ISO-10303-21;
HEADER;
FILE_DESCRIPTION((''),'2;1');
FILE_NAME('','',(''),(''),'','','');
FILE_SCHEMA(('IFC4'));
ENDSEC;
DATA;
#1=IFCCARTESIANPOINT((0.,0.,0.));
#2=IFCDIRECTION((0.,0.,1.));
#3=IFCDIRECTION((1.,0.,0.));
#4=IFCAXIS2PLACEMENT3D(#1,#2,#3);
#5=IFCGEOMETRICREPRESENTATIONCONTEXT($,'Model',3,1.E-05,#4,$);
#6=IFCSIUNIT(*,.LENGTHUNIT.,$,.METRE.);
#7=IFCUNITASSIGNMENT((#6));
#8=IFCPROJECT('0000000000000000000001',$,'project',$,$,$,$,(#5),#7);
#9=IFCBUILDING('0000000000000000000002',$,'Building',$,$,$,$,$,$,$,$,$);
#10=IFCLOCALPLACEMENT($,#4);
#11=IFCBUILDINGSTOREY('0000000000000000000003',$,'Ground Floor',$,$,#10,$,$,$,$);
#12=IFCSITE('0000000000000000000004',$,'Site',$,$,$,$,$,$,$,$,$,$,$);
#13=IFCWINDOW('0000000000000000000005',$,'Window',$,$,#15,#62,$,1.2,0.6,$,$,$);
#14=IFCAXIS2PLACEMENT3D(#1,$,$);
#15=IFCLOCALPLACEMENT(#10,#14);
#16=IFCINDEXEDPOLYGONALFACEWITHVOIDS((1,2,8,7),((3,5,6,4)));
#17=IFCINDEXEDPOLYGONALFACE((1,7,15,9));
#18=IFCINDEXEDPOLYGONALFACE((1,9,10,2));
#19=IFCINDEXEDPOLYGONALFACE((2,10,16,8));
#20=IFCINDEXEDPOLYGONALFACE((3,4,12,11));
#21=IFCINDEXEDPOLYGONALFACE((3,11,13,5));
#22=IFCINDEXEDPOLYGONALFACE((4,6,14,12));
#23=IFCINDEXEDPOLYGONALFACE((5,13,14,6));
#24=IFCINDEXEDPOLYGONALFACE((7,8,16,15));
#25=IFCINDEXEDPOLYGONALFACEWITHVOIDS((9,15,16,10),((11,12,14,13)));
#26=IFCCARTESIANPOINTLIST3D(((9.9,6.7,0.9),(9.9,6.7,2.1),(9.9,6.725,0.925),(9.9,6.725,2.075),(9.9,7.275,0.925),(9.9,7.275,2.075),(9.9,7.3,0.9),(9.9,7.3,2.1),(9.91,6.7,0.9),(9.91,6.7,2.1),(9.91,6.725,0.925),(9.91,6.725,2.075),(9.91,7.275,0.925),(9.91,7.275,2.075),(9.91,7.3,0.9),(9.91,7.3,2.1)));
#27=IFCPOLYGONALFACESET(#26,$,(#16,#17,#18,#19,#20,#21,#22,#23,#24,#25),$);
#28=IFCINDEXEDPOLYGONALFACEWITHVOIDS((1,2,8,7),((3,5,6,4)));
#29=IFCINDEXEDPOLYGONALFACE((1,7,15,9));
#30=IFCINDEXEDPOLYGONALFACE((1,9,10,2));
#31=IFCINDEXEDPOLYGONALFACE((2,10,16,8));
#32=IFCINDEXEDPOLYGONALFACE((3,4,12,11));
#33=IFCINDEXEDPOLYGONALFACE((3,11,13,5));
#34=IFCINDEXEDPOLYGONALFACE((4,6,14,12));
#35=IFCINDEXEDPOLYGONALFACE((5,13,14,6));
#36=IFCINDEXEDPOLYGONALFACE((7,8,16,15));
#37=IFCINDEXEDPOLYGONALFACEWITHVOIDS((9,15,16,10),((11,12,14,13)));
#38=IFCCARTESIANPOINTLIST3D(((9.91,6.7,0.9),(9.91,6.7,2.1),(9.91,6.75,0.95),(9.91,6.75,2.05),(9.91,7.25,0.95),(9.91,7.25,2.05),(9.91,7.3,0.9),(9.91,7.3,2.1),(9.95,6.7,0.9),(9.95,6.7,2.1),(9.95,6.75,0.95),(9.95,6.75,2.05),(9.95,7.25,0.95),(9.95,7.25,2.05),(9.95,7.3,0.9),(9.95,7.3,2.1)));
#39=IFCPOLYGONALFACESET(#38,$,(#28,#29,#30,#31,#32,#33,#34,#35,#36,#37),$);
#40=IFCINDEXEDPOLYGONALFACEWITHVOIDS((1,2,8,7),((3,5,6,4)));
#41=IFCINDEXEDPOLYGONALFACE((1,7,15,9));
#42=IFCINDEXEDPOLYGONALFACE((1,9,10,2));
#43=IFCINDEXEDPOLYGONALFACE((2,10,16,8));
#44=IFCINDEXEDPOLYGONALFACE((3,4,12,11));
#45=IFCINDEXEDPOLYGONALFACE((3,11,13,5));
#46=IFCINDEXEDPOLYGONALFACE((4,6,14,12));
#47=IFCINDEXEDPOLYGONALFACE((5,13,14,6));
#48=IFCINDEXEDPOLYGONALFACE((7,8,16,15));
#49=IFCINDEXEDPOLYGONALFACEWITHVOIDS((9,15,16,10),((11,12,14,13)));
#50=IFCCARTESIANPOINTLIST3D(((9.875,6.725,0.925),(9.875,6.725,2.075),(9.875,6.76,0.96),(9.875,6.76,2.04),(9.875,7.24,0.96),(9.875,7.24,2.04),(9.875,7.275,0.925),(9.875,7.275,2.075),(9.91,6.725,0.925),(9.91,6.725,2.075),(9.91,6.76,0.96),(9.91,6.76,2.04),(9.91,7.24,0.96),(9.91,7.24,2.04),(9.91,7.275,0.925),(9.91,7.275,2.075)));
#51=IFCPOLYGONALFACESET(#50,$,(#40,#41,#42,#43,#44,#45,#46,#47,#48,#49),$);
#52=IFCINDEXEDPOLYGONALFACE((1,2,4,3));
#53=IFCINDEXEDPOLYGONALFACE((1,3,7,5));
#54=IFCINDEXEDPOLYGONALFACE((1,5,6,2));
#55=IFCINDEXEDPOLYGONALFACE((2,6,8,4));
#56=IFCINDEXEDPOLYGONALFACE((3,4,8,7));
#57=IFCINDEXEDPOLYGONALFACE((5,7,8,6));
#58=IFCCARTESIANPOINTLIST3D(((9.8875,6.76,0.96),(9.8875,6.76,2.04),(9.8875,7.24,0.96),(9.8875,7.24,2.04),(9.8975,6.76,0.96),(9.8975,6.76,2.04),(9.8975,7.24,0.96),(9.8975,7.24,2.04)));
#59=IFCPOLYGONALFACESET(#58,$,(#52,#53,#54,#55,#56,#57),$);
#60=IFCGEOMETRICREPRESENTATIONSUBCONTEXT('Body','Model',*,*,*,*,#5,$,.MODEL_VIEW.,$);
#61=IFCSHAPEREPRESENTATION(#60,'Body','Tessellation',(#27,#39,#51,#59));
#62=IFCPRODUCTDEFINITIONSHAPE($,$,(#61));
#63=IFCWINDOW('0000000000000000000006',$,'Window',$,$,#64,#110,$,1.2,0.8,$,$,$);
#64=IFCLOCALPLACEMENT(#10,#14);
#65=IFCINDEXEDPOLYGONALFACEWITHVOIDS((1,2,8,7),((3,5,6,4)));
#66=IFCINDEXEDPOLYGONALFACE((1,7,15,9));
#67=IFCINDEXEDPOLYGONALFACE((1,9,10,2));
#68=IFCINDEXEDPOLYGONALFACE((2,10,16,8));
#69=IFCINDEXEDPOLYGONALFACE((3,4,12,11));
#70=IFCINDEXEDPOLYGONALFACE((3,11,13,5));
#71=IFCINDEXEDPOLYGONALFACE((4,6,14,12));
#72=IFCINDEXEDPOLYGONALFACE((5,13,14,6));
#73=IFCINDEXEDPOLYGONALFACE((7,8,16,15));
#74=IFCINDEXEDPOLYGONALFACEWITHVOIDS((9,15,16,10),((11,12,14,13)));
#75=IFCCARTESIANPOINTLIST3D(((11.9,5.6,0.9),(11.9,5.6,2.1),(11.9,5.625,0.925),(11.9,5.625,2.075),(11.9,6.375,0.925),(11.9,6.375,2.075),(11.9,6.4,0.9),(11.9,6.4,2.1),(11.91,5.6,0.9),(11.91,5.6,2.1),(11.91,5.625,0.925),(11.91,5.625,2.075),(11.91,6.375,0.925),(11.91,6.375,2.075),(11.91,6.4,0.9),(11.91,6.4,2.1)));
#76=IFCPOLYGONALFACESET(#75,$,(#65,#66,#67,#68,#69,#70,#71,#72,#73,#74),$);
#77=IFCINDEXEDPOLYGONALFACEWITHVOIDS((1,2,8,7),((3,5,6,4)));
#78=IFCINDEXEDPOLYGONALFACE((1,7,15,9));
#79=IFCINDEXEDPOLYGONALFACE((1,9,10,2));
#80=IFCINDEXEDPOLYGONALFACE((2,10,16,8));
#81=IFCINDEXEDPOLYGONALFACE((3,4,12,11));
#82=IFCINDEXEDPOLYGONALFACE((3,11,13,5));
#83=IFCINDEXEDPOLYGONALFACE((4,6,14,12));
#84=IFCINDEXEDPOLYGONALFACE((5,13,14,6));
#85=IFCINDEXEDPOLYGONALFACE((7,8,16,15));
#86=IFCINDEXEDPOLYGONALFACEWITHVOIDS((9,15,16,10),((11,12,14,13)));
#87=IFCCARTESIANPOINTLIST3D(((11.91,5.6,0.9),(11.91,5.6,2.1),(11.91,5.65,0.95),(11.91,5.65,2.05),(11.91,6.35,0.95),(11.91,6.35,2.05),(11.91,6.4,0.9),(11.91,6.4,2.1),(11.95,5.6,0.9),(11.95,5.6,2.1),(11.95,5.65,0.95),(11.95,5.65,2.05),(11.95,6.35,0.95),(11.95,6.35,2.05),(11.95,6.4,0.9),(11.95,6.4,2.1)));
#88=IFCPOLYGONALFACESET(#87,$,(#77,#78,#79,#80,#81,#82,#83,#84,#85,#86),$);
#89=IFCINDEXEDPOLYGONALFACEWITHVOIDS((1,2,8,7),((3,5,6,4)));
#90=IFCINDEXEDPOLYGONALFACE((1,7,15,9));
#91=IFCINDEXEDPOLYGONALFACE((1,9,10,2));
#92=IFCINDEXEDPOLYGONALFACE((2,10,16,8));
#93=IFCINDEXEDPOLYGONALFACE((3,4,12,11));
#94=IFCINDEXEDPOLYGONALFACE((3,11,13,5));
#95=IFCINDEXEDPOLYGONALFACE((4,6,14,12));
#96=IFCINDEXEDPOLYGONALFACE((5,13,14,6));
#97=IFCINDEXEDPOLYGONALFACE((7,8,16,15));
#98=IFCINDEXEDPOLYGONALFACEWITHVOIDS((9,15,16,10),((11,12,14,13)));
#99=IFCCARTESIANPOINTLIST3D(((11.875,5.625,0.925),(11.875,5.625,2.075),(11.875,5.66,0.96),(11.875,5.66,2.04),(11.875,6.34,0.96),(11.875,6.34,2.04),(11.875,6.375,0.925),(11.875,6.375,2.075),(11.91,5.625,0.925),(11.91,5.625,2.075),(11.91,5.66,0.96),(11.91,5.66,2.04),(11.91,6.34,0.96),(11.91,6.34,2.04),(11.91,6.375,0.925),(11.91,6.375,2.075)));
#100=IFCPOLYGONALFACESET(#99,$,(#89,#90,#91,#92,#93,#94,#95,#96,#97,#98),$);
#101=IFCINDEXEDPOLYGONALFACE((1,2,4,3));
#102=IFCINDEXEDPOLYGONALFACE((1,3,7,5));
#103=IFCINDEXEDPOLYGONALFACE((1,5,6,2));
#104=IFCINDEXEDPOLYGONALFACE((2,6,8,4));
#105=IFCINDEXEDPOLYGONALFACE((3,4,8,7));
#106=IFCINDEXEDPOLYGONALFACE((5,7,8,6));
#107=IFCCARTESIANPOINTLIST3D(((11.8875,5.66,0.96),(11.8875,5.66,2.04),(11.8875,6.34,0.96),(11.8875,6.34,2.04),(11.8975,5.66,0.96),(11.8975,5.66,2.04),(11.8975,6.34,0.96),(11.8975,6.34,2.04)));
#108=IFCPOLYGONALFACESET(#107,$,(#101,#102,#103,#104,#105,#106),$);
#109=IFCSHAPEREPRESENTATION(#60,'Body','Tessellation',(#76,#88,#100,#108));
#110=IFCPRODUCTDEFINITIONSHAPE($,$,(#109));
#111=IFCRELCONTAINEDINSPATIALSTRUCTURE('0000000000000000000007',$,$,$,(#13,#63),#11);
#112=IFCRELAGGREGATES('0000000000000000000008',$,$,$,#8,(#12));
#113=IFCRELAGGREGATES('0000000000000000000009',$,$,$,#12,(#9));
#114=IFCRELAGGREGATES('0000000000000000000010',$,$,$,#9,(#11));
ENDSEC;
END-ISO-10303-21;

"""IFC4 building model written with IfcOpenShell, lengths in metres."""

from ifc_helpers import new_model, si_unit, frame, origin_with_axes, place, context, subcontext, project, spatial, line, indexed_curve, outline, extrude, element, save


model = new_model("IFC4")

# Units and contexts
model_context = context("Model", 3, precision=1e-05, world=origin_with_axes())
body_context = subcontext(model_context, "Body", "Model", "MODEL_VIEW")
ifc_project = project(units=[si_unit("LENGTHUNIT", "METRE")], contexts=[model_context])

# Site, building, storey
site = spatial("IfcSite", under=ifc_project, Name="Site")
building = spatial("IfcBuilding", under=site, Name="Building")
storey_placement = place(None, origin_with_axes())
storey = spatial("IfcBuildingStorey", under=building, at=storey_placement, Name="Ground Floor")

# Windows
window_1_placement = place(storey_placement, frame((10.0, 6.7, 0.9), z_axis=(0.0, 0.0, 1.0), x_axis=(0.0, 1.0, 0.0)))
element("IfcWindow", 1, at=window_1_placement, inside=storey, Name="Window", OverallHeight=1.2, OverallWidth=0.6, context=body_context, shape_type="SweptSolid", body=[
    extrude(outline(indexed_curve([(0.0, 0.0), (0.6, 0.0), (0.6, 1.2), (0.0, 1.2)], segments=[line(1, 2, 3, 4, 1)]), holes=[indexed_curve([(0.025, 0.025), (0.575, 0.025), (0.575, 1.175), (0.025, 1.175)], segments=[line(1, 2, 3, 4, 1)])]), frame((0.0, 0.09, 0.0), z_axis=(0.0, -1.0, 0.0), x_axis=(1.0, 0.0, 0.0)), (0.0, 0.0, -1.0), 0.01),
    extrude(outline(indexed_curve([(0.0, 0.0), (0.6, 0.0), (0.6, 1.2), (0.0, 1.2)], segments=[line(1, 2, 3, 4, 1)]), holes=[indexed_curve([(0.05, 0.05), (0.55, 0.05), (0.55, 1.15), (0.05, 1.15)], segments=[line(1, 2, 3, 4, 1)])]), frame((0.0, 0.05, 0.0), z_axis=(0.0, -1.0, 0.0), x_axis=(1.0, 0.0, 0.0)), (0.0, 0.0, -1.0), 0.04),
    extrude(outline(indexed_curve([(0.0, 0.0), (0.55, 0.0), (0.55, 1.15), (0.0, 1.15)], segments=[line(1, 2, 3, 4, 1)]), holes=[indexed_curve([(0.035, 0.035), (0.515, 0.035), (0.515, 1.115), (0.035, 1.115)], segments=[line(1, 2, 3, 4, 1)])]), frame((0.025, 0.09, 0.025), z_axis=(0.0, -1.0, 0.0), x_axis=(1.0, 0.0, 0.0)), (0.0, 0.0, -1.0), 0.035),
    extrude(outline(indexed_curve([(0.035, 0.035), (0.515, 0.035), (0.515, 1.115), (0.035, 1.115)], segments=[line(1, 2, 3, 4, 1)])), frame((0.025, 0.1025, 0.025), z_axis=(0.0, -1.0, 0.0), x_axis=(1.0, 0.0, 0.0)), (0.0, 0.0, -1.0), 0.01),
])
window_2_placement = place(storey_placement, frame((12.0, 5.6, 0.9), z_axis=(0.0, 0.0, 1.0), x_axis=(0.0, 1.0, 0.0)))
element("IfcWindow", 2, at=window_2_placement, inside=storey, Name="Window", OverallHeight=1.2, OverallWidth=0.8, context=body_context, shape_type="SweptSolid", body=[
    extrude(outline(indexed_curve([(0.0, 0.0), (0.8, 0.0), (0.8, 1.2), (0.0, 1.2)], segments=[line(1, 2, 3, 4, 1)]), holes=[indexed_curve([(0.025, 0.025), (0.775, 0.025), (0.775, 1.175), (0.025, 1.175)], segments=[line(1, 2, 3, 4, 1)])]), frame((0.0, 0.09, 0.0), z_axis=(0.0, -1.0, 0.0), x_axis=(1.0, 0.0, 0.0)), (0.0, 0.0, -1.0), 0.01),
    extrude(outline(indexed_curve([(0.0, 0.0), (0.8, 0.0), (0.8, 1.2), (0.0, 1.2)], segments=[line(1, 2, 3, 4, 1)]), holes=[indexed_curve([(0.05, 0.05), (0.75, 0.05), (0.75, 1.15), (0.05, 1.15)], segments=[line(1, 2, 3, 4, 1)])]), frame((0.0, 0.05, 0.0), z_axis=(0.0, -1.0, 0.0), x_axis=(1.0, 0.0, 0.0)), (0.0, 0.0, -1.0), 0.04),
    extrude(outline(indexed_curve([(0.0, 0.0), (0.75, 0.0), (0.75, 1.15), (0.0, 1.15)], segments=[line(1, 2, 3, 4, 1)]), holes=[indexed_curve([(0.035, 0.035), (0.715, 0.035), (0.715, 1.115), (0.035, 1.115)], segments=[line(1, 2, 3, 4, 1)])]), frame((0.025, 0.09, 0.025), z_axis=(0.0, -1.0, 0.0), x_axis=(1.0, 0.0, 0.0)), (0.0, 0.0, -1.0), 0.035),
    extrude(outline(indexed_curve([(0.035, 0.035), (0.715, 0.035), (0.715, 1.115), (0.035, 1.115)], segments=[line(1, 2, 3, 4, 1)])), frame((0.025, 0.1025, 0.025), z_axis=(0.0, -1.0, 0.0), x_axis=(1.0, 0.0, 0.0)), (0.0, 0.0, -1.0), 0.01),
])

save(model, "model.ifc")
